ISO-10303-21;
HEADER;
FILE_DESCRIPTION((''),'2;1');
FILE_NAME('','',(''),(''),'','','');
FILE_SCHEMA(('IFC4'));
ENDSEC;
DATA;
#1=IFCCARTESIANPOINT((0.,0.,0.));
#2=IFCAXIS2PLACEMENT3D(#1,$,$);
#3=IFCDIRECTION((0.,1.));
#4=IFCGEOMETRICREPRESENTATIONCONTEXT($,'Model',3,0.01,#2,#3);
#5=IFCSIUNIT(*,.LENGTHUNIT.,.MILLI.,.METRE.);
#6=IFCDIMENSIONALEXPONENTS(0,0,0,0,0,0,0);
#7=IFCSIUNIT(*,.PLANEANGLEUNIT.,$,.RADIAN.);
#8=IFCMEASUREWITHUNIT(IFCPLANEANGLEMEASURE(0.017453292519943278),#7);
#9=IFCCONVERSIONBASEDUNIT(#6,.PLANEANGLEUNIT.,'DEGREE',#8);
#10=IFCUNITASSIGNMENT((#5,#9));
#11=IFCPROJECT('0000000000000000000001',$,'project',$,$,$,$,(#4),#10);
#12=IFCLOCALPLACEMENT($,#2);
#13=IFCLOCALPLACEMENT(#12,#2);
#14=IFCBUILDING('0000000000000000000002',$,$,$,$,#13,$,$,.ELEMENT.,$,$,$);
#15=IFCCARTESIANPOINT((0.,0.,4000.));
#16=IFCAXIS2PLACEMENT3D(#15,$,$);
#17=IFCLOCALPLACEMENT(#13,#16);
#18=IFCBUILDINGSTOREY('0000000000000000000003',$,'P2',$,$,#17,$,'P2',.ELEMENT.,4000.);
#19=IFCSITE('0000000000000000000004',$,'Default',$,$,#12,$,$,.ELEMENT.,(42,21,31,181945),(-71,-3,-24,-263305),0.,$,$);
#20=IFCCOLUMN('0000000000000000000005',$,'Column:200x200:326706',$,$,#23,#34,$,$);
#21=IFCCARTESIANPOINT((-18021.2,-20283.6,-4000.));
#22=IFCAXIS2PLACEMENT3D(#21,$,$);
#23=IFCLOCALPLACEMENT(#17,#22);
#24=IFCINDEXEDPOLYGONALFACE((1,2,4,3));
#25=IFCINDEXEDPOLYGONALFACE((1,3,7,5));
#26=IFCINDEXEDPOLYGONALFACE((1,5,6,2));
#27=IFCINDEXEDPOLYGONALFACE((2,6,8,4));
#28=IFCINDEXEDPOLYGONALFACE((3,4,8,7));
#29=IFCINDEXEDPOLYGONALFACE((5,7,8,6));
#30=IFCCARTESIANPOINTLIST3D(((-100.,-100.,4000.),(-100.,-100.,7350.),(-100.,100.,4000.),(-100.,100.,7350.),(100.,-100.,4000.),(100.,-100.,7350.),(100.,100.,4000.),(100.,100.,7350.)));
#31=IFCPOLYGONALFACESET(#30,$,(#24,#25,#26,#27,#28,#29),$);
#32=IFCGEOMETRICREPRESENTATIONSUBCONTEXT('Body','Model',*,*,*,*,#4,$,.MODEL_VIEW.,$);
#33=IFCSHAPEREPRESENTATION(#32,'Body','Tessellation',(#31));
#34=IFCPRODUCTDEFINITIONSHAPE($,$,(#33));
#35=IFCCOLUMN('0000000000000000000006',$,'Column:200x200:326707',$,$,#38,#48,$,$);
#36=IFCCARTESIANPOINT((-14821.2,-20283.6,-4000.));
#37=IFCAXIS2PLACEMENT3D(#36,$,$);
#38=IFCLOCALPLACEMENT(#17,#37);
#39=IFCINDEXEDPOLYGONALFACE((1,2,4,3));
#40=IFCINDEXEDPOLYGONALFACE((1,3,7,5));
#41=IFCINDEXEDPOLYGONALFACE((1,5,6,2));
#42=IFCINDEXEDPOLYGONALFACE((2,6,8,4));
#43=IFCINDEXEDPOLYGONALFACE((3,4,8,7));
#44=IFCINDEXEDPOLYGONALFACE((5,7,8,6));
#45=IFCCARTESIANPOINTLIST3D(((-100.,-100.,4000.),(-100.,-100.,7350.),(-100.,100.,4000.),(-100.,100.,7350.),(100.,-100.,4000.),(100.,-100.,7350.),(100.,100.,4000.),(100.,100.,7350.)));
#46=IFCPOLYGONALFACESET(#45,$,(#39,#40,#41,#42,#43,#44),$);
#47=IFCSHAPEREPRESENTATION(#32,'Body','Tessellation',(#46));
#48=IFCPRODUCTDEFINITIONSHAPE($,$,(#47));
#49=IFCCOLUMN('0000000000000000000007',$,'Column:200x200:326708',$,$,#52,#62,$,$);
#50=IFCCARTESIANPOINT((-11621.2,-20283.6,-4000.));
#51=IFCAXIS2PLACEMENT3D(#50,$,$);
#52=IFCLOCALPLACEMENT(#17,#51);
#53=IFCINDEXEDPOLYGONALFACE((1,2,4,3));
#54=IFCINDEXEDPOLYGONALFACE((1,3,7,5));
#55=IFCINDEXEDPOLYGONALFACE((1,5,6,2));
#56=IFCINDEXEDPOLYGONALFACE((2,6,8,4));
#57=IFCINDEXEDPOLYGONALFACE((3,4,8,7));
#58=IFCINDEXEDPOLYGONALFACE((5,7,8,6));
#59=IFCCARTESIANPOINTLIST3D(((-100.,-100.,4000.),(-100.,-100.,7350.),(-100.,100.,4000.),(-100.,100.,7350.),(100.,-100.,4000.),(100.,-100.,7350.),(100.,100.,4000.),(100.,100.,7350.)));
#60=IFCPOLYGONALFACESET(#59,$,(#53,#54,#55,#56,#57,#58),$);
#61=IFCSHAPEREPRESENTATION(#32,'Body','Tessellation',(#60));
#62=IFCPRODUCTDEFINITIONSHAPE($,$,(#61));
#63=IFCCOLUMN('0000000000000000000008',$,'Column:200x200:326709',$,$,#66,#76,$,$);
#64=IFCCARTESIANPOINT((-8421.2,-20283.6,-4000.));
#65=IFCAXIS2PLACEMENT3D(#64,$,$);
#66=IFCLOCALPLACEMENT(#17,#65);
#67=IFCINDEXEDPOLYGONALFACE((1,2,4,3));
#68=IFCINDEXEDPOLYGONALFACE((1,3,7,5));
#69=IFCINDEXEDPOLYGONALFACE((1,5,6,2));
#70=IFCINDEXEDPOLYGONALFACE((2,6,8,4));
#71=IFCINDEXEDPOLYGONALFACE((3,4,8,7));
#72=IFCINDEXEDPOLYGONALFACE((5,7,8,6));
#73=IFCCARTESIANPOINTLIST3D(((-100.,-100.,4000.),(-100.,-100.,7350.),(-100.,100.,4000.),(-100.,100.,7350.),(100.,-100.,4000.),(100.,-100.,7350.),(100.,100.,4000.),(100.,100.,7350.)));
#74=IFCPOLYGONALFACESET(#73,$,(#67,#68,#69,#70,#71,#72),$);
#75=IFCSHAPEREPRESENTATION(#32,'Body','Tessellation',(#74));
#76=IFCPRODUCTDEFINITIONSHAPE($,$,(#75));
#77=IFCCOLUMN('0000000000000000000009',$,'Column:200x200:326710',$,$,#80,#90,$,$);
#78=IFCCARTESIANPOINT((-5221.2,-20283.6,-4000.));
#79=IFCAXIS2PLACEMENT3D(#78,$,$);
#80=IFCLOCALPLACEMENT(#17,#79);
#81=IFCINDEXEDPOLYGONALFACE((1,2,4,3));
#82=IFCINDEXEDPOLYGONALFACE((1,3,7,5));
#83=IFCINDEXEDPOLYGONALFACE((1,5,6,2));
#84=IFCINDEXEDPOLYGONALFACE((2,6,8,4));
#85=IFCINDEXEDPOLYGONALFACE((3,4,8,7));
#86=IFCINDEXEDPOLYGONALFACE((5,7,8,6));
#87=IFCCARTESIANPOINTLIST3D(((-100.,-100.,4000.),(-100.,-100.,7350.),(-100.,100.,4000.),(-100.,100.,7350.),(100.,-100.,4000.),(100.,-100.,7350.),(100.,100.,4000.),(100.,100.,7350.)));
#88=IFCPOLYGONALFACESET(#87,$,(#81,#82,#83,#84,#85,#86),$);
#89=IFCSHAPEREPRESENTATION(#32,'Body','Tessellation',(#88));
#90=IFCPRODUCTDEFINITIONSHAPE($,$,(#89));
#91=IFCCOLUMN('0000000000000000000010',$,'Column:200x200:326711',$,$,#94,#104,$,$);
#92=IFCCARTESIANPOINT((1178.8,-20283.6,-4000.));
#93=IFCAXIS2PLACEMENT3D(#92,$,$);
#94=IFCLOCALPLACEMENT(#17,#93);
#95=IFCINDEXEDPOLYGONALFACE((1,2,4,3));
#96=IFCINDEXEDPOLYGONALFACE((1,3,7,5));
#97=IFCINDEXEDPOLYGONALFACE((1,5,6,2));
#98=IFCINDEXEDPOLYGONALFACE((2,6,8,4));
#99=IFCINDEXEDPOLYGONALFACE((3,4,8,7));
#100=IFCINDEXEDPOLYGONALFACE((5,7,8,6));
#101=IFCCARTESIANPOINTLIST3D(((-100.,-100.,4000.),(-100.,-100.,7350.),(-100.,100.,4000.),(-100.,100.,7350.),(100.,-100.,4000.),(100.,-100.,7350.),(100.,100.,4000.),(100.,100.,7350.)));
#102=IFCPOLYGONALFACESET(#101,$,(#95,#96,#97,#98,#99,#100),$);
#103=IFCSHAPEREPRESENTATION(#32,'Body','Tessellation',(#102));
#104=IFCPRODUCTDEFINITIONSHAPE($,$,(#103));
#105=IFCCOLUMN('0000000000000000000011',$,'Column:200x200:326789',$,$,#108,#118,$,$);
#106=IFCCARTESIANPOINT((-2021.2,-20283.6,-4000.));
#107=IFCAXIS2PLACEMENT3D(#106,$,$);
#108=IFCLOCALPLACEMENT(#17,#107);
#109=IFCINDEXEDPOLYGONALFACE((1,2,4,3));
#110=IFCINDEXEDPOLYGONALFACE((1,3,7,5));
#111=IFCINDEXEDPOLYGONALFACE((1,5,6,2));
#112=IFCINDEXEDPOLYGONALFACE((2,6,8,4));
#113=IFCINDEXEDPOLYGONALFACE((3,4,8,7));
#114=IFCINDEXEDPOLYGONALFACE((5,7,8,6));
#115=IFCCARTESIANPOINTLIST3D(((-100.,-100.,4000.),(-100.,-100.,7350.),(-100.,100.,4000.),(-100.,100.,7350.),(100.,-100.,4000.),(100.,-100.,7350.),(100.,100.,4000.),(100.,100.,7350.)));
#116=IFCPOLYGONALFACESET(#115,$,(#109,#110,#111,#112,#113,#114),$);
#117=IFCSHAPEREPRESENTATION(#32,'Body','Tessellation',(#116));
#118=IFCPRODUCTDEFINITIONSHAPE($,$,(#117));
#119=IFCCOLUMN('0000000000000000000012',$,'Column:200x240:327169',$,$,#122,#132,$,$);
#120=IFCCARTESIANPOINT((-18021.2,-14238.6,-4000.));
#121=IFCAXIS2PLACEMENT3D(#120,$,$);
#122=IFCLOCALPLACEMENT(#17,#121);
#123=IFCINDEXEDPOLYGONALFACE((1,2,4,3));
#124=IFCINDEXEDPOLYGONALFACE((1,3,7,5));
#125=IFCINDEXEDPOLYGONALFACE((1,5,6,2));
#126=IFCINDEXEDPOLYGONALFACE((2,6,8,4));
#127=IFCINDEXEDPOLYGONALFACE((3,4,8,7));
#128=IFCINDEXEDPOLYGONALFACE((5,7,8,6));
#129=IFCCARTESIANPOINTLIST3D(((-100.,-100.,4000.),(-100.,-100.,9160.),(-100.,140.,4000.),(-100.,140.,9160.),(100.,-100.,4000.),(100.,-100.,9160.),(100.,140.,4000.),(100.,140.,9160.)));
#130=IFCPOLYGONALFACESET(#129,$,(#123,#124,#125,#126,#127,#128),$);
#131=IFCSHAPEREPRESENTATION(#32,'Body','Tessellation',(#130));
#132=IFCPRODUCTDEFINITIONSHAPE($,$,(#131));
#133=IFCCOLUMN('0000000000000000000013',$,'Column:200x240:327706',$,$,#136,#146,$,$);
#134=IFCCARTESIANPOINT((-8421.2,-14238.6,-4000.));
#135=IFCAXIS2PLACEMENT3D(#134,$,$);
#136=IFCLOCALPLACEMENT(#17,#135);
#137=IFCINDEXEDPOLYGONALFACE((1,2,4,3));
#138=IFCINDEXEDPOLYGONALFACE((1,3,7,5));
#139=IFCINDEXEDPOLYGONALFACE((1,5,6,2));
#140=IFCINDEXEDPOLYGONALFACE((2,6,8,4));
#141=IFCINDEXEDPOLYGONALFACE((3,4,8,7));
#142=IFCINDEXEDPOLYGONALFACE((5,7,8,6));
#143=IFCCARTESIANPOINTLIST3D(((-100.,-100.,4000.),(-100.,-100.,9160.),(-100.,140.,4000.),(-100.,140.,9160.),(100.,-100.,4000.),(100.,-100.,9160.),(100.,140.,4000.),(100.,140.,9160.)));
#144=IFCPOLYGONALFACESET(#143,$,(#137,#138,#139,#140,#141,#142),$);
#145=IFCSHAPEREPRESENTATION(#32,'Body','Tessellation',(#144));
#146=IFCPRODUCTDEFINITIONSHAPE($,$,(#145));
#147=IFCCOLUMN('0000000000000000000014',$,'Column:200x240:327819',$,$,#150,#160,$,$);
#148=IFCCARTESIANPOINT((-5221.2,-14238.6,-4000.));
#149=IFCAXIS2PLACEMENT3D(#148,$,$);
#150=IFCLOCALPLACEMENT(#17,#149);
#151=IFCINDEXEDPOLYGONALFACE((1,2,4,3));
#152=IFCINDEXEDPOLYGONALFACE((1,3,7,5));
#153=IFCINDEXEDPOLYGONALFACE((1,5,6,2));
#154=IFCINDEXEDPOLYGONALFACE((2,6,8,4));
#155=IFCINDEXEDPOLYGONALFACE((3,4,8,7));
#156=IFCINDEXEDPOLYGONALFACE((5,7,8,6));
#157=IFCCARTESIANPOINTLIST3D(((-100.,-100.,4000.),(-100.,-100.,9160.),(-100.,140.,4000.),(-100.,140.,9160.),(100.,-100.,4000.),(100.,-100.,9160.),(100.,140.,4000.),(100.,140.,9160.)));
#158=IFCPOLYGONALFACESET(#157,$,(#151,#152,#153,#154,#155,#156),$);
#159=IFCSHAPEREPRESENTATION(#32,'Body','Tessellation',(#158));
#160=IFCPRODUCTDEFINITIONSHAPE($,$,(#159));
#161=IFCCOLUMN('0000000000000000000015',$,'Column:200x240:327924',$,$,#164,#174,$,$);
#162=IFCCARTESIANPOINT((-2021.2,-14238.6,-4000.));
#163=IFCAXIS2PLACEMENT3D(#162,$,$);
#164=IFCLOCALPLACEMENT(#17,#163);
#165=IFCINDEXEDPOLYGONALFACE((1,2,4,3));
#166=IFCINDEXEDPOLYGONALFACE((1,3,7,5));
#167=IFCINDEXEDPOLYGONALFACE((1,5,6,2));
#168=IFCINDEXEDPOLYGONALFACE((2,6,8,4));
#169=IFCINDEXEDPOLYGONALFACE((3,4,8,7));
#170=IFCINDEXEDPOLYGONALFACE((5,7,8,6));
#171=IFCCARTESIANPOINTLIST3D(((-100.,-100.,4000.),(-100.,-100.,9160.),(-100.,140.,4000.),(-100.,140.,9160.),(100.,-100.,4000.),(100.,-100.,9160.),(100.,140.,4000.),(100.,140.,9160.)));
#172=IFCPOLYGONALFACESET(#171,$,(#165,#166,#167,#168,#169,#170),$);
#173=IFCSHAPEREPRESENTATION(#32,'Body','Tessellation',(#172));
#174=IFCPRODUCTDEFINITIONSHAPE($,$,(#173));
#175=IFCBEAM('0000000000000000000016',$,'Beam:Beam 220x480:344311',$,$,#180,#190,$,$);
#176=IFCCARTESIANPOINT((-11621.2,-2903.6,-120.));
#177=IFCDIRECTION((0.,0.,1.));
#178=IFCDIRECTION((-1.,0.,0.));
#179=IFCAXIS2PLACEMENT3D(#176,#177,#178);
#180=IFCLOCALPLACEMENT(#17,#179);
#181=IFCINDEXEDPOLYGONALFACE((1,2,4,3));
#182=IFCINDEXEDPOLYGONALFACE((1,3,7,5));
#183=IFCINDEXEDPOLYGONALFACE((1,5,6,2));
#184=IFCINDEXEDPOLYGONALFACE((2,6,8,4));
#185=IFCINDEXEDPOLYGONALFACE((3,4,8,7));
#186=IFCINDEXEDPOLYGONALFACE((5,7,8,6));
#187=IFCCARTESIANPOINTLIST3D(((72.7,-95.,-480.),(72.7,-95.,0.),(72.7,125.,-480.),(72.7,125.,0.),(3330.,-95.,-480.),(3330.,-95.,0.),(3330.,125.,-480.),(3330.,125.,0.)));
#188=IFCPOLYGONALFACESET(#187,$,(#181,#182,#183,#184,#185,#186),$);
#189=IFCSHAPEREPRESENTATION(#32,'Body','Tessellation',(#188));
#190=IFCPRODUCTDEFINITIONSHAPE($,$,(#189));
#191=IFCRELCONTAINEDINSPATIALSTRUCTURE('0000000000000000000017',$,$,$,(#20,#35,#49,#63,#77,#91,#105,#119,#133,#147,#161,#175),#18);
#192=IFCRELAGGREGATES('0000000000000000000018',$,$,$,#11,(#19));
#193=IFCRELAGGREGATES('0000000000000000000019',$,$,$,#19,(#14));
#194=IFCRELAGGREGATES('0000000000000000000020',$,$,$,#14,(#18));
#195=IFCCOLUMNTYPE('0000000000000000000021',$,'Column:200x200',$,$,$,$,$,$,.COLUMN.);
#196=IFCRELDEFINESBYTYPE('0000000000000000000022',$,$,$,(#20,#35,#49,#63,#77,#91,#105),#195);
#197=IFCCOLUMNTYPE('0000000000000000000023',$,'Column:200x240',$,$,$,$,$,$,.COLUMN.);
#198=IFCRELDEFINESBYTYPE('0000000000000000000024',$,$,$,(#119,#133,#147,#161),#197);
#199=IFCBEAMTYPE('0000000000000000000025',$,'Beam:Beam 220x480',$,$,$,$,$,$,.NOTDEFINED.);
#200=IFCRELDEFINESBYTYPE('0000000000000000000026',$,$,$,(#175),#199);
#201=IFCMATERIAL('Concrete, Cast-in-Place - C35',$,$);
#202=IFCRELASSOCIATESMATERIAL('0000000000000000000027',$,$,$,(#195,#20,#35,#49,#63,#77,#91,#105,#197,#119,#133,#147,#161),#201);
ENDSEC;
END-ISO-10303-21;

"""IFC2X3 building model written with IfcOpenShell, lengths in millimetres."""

from ifc_helpers import new_model, entity, si_unit, converted_unit, direction, frame, frame_2d, origin, origin_2d_with_axis, place, context, subcontext, project, spatial, rectangle, extrude, source, transform, mapped, material, type_object, type_shapes, element, save


model = new_model("IFC2X3")

# Units and contexts
model_context = context("Model", 3, precision=0.01, world=origin(), true_north=direction((0.0, 1.0)))
body_context = subcontext(model_context, "Body", "Model", "MODEL_VIEW")
ifc_project = project(units=[si_unit("LENGTHUNIT", "METRE", prefix="MILLI"), converted_unit("PLANEANGLEUNIT", "DEGREE", entity("IfcPlaneAngleMeasure", 0.017453292519943278), si_unit("PLANEANGLEUNIT", "RADIAN"), dimensions=[0, 0, 0, 0, 0, 0, 0])], contexts=[model_context])

# Site, building, storey
site_placement = place(None, origin())
site = spatial("IfcSite", under=ifc_project, at=site_placement, Name="Default", CompositionType="ELEMENT", RefLatitude=(42, 21, 31, 181945), RefLongitude=(-71, -3, -24, -263305), RefElevation=0.0)
building_placement = place(site_placement, origin())
building = spatial("IfcBuilding", under=site, at=building_placement, CompositionType="ELEMENT")
storey_placement = place(building_placement, frame((0.0, 0.0, 4000.0)))
storey = spatial("IfcBuildingStorey", under=building, at=storey_placement, Name="P2", LongName="P2", CompositionType="ELEMENT", Elevation=4000.0)

# Columns
ifc_material_1 = material(Name="Concrete, Cast-in-Place - C35")
column_type_1 = type_object("IfcColumnType", Name="Column:200x200", PredefinedType="COLUMN", material=ifc_material_1)
shared_shape_1 = source(origin(), body_context, "Body", "SweptSolid", [
    extrude(rectangle(XDim=200.0, YDim=200.0, at=frame_2d((0.0, 0.0), x_axis=(1.0, 0.0))), frame((0.0, 0.0, 4000.0), z_axis=(0.0, 0.0, 1.0), x_axis=(-1.0, 0.0, 0.0)), (0.0, 0.0, 1.0), 3350.0),
])
type_shapes(column_type_1, [shared_shape_1])
for number, where, name in (
    (1, (-18021.2, -20283.6, -4000.0), "Column:200x200:326706"),
    (2, (-14821.2, -20283.6, -4000.0), "Column:200x200:326707"),
    (3, (-11621.2, -20283.6, -4000.0), "Column:200x200:326708"),
    (4, (-8421.2, -20283.6, -4000.0), "Column:200x200:326709"),
    (5, (-5221.2, -20283.6, -4000.0), "Column:200x200:326710"),
    (6, (1178.8, -20283.6, -4000.0), "Column:200x200:326711"),
    (7, (-2021.2, -20283.6, -4000.0), "Column:200x200:326789"),
):
    element("IfcColumn", number, at=place(storey_placement, frame(where)), inside=storey, type_object=column_type_1, material=ifc_material_1, Name=name, context=body_context, shape_type="MappedRepresentation", body=[
        mapped(shared_shape_1, transform((0.0, 0.0, 0.0), scale=1.0)),
    ])
column_type_2 = type_object("IfcColumnType", Name="Column:200x240", PredefinedType="COLUMN", material=ifc_material_1)
shared_shape_2 = source(origin(), body_context, "Body", "SweptSolid", [
    extrude(rectangle(XDim=200.0, YDim=240.0, at=origin_2d_with_axis()), frame((0.0, 20.0, 4000.0), z_axis=(0.0, 0.0, 1.0), x_axis=(-1.0, 0.0, 0.0)), (0.0, 0.0, 1.0), 5160.0),
])
type_shapes(column_type_2, [shared_shape_2])
for number, where, name in (
    (8, (-18021.2, -14238.6, -4000.0), "Column:200x240:327169"),
    (9, (-8421.2, -14238.6, -4000.0), "Column:200x240:327706"),
    (10, (-5221.2, -14238.6, -4000.0), "Column:200x240:327819"),
    (11, (-2021.2, -14238.6, -4000.0), "Column:200x240:327924"),
):
    element("IfcColumn", number, at=place(storey_placement, frame(where)), inside=storey, type_object=column_type_2, material=ifc_material_1, Name=name, context=body_context, shape_type="MappedRepresentation", body=[
        mapped(shared_shape_2, transform((0.0, 0.0, 0.0), scale=1.0)),
    ])

# Beam
beam_type_1 = type_object("IfcBeamType", Name="Beam:Beam 220x480", PredefinedType="NOTDEFINED")
beam_1_placement = place(storey_placement, frame((-11621.2, -2903.6, -120.0), z_axis=(0.0, 0.0, 1.0), x_axis=(-1.0, 0.0, 0.0)))
element("IfcBeam", 12, at=beam_1_placement, inside=storey, type_object=beam_type_1, Name="Beam:Beam 220x480:344311", context=body_context, shape_type="SweptSolid", body=[
    extrude(rectangle(XDim=480.0, YDim=220.0, at=frame_2d((0.0, 0.0), x_axis=(1.0, 0.0))), frame((72.7, 15.0, -240.0), z_axis=(1.0, 0.0, 0.0), x_axis=(0.0, 0.0, -1.0)), (0.0, 0.0, 1.0), 3257.3),
])

save(model, "model.ifc")
